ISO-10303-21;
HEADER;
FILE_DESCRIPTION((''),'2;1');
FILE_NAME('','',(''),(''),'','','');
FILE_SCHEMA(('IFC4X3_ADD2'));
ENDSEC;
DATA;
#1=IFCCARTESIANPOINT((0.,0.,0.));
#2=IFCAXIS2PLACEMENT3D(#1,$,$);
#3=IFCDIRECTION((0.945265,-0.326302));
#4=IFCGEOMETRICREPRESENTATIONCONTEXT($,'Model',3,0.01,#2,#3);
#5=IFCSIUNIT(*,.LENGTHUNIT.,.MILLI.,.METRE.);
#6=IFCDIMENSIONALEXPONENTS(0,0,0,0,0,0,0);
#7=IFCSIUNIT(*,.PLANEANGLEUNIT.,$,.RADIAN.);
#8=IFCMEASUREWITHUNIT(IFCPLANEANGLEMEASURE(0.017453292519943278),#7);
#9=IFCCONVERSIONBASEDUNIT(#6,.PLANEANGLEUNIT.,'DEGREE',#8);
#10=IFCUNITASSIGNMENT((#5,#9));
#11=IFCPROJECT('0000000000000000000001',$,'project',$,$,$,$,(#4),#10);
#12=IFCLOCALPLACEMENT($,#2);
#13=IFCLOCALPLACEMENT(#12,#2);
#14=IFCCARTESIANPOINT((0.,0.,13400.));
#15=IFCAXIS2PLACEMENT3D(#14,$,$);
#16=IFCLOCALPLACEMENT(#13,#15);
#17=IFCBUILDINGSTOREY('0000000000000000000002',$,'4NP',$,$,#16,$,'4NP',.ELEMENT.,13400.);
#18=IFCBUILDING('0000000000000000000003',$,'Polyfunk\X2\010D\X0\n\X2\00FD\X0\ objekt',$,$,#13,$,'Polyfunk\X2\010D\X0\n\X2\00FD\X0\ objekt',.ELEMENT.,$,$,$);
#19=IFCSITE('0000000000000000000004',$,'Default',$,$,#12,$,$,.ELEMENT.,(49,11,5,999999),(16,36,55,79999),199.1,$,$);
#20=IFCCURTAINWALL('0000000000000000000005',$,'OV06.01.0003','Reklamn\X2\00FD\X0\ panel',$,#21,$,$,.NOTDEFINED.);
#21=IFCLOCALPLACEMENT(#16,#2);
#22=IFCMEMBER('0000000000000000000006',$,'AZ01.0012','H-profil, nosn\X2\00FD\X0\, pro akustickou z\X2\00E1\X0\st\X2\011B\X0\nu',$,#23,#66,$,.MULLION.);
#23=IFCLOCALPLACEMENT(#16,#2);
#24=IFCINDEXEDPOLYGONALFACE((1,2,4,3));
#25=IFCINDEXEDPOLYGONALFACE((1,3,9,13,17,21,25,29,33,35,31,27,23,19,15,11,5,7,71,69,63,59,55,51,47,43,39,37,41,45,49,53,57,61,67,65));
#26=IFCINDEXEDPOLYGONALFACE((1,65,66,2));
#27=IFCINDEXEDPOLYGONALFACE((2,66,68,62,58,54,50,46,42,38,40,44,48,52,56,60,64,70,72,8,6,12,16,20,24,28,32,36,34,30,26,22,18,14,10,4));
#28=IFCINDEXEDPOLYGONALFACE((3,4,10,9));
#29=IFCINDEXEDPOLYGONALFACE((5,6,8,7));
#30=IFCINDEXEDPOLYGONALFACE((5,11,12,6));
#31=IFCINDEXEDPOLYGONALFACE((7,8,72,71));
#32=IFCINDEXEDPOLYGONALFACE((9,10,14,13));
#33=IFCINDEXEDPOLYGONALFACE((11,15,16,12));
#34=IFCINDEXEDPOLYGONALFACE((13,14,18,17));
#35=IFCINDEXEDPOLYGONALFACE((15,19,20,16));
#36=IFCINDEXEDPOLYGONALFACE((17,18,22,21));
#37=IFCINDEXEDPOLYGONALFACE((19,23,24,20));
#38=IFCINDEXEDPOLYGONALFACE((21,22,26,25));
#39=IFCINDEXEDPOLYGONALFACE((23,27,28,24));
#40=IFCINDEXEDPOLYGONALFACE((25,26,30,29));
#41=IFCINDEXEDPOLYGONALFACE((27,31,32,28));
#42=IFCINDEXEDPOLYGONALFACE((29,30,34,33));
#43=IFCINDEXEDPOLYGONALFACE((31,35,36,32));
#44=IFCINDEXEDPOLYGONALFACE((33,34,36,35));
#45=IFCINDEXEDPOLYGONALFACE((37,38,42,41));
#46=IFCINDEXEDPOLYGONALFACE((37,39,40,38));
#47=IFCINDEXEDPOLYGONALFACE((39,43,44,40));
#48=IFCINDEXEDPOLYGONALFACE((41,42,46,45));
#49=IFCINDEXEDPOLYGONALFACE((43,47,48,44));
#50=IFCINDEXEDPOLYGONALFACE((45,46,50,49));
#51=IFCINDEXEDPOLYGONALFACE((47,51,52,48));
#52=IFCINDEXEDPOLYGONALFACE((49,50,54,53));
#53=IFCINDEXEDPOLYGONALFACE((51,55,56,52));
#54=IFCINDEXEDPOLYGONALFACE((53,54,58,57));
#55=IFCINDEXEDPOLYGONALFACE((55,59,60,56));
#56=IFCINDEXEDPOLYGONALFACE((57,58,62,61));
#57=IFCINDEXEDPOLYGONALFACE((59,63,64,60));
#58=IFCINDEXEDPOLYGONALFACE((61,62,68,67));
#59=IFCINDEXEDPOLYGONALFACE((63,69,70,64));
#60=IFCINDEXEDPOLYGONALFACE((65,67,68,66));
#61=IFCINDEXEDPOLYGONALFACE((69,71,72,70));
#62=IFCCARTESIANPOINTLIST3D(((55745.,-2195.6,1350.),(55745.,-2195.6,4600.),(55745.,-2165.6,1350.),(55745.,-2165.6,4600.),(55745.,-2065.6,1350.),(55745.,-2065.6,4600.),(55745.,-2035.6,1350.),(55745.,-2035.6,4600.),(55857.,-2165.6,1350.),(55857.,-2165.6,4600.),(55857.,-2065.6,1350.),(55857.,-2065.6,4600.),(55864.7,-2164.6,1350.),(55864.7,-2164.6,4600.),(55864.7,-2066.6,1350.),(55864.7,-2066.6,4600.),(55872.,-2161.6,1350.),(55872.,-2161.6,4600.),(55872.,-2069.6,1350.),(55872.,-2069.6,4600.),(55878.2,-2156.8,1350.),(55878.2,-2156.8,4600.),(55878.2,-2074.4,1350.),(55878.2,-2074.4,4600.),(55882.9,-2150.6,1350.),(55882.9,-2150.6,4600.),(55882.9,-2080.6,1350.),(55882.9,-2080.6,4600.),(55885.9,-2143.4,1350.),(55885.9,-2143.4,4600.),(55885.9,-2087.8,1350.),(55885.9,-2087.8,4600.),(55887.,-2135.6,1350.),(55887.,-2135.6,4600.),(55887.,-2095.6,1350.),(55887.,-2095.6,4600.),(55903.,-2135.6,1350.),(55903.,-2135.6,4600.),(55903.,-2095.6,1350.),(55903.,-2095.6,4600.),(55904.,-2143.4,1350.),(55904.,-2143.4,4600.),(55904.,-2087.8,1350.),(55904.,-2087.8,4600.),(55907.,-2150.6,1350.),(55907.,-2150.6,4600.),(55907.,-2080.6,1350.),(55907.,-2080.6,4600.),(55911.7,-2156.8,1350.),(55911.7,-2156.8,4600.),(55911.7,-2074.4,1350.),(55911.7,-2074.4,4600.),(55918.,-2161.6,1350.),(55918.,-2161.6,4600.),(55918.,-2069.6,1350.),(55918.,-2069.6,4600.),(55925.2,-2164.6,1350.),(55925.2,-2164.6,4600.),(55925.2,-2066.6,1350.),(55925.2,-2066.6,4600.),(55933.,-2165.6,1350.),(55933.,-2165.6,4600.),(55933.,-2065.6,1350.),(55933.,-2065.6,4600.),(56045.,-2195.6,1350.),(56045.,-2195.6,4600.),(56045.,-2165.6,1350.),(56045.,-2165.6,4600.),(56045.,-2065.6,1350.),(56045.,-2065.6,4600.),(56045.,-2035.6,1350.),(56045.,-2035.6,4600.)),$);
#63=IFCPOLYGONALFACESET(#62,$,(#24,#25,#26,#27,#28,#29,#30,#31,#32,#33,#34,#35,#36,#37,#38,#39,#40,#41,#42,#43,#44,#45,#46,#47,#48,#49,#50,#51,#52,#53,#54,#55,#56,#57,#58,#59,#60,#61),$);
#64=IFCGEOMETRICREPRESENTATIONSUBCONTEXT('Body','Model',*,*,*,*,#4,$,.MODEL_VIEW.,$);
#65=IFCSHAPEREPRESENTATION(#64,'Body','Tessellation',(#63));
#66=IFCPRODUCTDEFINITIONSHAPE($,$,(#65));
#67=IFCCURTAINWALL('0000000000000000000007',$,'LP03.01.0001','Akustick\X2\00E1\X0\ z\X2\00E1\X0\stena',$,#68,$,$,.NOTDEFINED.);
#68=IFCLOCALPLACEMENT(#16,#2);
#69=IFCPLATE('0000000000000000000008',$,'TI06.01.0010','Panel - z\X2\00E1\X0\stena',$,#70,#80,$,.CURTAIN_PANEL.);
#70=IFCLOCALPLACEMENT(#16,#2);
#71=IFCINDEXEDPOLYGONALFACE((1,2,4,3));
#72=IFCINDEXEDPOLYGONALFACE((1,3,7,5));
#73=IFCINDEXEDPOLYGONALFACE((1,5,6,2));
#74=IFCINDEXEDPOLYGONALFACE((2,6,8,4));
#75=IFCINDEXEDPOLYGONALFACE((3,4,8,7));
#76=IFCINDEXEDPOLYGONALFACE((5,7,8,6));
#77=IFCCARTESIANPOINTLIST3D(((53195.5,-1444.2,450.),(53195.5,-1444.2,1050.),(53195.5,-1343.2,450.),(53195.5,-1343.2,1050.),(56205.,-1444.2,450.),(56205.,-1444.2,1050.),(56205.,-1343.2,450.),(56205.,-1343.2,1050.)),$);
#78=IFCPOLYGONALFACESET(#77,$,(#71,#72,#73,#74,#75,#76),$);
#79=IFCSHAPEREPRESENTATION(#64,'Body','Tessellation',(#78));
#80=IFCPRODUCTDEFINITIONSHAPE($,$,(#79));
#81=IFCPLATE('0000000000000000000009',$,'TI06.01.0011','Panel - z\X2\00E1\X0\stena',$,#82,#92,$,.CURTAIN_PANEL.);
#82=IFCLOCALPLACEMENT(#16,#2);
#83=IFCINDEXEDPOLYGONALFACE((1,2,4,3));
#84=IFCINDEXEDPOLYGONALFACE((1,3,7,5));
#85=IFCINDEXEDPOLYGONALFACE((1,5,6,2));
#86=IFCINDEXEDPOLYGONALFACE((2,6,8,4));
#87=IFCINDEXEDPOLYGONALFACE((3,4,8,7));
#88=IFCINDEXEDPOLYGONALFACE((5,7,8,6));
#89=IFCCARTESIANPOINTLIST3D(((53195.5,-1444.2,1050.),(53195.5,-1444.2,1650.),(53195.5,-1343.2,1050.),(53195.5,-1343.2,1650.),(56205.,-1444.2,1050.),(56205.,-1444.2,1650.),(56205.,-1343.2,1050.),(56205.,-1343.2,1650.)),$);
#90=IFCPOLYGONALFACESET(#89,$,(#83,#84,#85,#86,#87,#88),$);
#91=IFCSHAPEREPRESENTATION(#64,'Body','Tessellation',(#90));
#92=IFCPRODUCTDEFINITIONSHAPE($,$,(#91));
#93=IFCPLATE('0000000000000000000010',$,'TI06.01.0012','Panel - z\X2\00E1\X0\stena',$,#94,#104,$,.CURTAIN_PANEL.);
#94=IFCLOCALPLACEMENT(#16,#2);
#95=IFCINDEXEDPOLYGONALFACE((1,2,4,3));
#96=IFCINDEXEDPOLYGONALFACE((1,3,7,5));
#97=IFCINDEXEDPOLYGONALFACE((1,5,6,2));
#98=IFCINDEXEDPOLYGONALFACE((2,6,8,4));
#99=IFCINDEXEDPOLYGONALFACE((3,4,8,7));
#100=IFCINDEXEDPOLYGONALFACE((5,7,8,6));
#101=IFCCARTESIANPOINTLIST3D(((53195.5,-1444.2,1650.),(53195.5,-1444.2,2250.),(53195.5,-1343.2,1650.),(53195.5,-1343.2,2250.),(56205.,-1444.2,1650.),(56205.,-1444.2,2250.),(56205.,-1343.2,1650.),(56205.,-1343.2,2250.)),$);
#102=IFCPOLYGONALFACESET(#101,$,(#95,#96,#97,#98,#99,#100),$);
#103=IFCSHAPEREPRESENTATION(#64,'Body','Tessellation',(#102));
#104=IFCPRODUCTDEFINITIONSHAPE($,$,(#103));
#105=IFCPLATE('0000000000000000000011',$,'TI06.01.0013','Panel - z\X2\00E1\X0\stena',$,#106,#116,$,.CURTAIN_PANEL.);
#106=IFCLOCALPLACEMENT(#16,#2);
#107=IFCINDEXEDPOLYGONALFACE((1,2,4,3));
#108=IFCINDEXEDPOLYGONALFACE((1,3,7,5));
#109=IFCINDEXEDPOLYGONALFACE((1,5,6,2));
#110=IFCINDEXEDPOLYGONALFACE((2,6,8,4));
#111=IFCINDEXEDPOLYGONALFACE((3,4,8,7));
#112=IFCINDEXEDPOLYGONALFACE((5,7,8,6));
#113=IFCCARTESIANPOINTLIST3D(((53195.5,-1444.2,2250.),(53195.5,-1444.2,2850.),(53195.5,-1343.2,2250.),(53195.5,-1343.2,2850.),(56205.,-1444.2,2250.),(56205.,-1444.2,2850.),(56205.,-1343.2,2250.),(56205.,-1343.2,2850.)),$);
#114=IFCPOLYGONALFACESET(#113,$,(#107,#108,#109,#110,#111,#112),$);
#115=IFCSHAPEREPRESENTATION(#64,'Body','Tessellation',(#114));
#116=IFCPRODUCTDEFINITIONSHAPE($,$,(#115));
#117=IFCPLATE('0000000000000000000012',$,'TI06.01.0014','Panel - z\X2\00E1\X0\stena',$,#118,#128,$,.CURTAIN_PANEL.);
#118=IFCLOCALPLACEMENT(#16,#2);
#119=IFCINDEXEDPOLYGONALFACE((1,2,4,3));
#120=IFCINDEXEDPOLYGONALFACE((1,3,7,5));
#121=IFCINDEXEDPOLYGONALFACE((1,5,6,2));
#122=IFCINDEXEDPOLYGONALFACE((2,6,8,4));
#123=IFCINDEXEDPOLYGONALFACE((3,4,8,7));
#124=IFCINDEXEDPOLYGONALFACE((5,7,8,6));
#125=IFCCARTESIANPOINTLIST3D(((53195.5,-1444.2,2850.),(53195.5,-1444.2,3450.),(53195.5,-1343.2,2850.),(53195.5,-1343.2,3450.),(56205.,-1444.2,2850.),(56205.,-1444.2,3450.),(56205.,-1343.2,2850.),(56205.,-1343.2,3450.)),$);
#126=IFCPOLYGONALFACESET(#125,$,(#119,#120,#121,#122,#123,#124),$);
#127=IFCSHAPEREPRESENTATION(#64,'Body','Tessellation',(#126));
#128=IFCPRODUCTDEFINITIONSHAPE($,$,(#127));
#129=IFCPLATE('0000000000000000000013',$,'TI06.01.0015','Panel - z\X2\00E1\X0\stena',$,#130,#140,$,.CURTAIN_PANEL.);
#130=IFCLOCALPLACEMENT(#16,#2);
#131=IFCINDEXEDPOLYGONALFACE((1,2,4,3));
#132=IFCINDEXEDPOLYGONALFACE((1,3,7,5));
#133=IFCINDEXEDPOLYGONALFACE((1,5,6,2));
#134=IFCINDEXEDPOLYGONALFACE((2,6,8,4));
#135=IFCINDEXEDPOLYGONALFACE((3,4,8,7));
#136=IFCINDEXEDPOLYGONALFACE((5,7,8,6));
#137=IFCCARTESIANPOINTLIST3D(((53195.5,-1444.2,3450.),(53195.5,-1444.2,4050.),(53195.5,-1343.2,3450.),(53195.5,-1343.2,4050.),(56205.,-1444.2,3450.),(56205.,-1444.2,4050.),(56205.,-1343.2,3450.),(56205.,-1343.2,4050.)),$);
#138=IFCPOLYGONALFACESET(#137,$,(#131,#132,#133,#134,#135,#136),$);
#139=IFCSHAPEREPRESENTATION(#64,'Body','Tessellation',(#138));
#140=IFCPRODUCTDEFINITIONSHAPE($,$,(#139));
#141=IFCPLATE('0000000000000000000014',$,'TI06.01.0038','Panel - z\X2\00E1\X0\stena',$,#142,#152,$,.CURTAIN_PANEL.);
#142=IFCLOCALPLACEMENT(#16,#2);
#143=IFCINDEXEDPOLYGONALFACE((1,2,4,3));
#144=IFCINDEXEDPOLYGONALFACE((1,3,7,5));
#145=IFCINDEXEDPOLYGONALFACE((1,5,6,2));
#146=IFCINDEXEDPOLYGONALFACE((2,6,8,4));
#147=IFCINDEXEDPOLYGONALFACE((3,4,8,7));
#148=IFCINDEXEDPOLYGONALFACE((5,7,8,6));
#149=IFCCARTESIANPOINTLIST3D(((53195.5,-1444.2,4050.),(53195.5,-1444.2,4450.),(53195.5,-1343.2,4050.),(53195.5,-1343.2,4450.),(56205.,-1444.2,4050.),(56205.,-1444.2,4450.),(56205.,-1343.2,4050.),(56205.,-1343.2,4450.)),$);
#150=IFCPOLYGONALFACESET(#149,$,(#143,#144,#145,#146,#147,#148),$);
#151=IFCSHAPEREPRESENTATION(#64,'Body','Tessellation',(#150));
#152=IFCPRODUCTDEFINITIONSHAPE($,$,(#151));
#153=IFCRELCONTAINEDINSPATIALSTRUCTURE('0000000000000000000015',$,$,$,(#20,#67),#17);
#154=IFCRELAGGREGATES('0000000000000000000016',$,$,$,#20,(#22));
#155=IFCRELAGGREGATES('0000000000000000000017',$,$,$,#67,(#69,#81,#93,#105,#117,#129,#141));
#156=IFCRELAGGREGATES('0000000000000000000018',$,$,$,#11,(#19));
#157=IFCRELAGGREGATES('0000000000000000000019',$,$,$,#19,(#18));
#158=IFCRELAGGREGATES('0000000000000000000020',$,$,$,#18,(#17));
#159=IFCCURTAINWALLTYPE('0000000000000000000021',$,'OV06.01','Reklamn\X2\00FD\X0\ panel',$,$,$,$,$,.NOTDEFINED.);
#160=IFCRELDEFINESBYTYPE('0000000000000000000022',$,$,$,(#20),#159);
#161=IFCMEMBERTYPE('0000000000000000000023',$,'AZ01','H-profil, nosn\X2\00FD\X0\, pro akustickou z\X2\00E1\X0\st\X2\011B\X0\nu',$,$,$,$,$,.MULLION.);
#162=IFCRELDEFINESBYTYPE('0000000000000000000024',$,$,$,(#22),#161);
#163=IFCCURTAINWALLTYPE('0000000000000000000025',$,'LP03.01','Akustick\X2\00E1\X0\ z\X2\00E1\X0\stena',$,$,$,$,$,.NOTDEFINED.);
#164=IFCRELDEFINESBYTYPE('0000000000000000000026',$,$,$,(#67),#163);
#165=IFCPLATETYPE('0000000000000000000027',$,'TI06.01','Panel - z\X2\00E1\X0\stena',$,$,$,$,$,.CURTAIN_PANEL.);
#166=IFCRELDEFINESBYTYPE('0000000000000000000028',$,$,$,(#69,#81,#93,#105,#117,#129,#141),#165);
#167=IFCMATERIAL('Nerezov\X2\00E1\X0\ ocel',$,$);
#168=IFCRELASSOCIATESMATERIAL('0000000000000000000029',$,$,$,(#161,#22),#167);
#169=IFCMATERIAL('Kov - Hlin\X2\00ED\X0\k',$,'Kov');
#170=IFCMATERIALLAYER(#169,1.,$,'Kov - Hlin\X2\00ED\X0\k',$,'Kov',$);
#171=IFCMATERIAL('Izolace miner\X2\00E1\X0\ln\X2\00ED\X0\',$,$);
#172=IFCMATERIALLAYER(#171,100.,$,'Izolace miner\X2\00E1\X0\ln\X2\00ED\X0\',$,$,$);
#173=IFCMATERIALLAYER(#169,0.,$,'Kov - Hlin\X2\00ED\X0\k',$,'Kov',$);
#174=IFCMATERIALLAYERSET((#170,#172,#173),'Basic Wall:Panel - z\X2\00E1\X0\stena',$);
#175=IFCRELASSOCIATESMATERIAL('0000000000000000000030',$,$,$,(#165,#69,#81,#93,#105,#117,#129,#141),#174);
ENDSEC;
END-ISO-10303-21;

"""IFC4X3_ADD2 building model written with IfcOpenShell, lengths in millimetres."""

from ifc_helpers import new_model, entity, si_unit, converted_unit, direction, frame, frame_2d, origin, place, context, subcontext, project, spatial, polyline, circle_curve, parameter, trimmed, segment, composite_curve, rectangle, outline, extrude, source, transform, mapped, material, layer, layer_set, layer_usage, material_profile, profile_set, profile_usage, type_object, element, aggregate, save


model = new_model("IFC4X3_ADD2")

# Units and contexts
model_context = context("Model", 3, precision=0.01, world=origin(), true_north=direction((0.945265, -0.326302)))
body_context = subcontext(model_context, "Body", "Model", "MODEL_VIEW")
ifc_project = project(units=[si_unit("LENGTHUNIT", "METRE", prefix="MILLI"), converted_unit("PLANEANGLEUNIT", "DEGREE", entity("IfcPlaneAngleMeasure", 0.017453292519943278), si_unit("PLANEANGLEUNIT", "RADIAN"), dimensions=[0, 0, 0, 0, 0, 0, 0])], contexts=[model_context])

# Site, building, storey
site_placement = place(None, origin())
site = spatial("IfcSite", under=ifc_project, at=site_placement, Name="Default", CompositionType="ELEMENT", RefLatitude=(49, 11, 5, 999999), RefLongitude=(16, 36, 55, 79999), RefElevation=199.1)
building_placement = place(site_placement, origin())
building = spatial("IfcBuilding", under=site, at=building_placement, Name="Polyfunkčný objekt", LongName="Polyfunkčný objekt", CompositionType="ELEMENT")
storey_placement = place(building_placement, frame((0.0, 0.0, 13400.0)))
storey = spatial("IfcBuildingStorey", under=building, at=storey_placement, Name="4NP", LongName="4NP", CompositionType="ELEMENT", Elevation=13400.0)

# Shared definitions
curtain_wall_type_1 = type_object("IfcCurtainWallType", Name="LP03.01", Description="Akustická zástena", PredefinedType="NOTDEFINED")
ifc_material_1 = material(Name="Nerezová ocel")
ifc_material_profile = material_profile(ifc_material_1, outline(composite_curve([segment(polyline([(50.0, -150.0), (80.0, -150.0)]), True, "CONTINUOUS"), segment(polyline([(80.0, -150.0), (80.0, 150.0)]), True, "CONTINUOUS"), segment(polyline([(80.0, 150.0), (50.0, 150.0)]), True, "CONTINUOUS"), segment(polyline([(50.0, 150.0), (50.0, 38.0)]), True, "CONTINUOUS"), segment(trimmed(circle_curve(frame_2d((20.0, 38.0), x_axis=(0.0, 1.0)), 30.0), [parameter(180.0)], [parameter(270.0)], True, "PARAMETER"), False, "CONTINUOUS"), segment(polyline([(20.0, 8.0), (-20.0, 8.0)]), True, "CONTINUOUS"), segment(trimmed(circle_curve(frame_2d((-20.0, 38.0), x_axis=(0.0, 1.0)), 30.0), [parameter(90.0)], [parameter(180.0)], True, "PARAMETER"), False, "CONTINUOUS"), segment(polyline([(-50.0, 38.0), (-50.0, 150.0)]), True, "CONTINUOUS"), segment(polyline([(-50.0, 150.0), (-80.0, 150.0)]), True, "CONTINUOUS"), segment(polyline([(-80.0, 150.0), (-80.0, -150.0)]), True, "CONTINUOUS"), segment(polyline([(-80.0, -150.0), (-50.0, -150.0)]), True, "CONTINUOUS"), segment(polyline([(-50.0, -150.0), (-50.0, -38.0)]), True, "CONTINUOUS"), segment(trimmed(circle_curve(frame_2d((-20.0, -38.0), x_axis=(0.0, 1.0)), 30.0), [parameter(0.0)], [parameter(90.0)], True, "PARAMETER"), False, "CONTINUOUS"), segment(polyline([(-20.0, -8.0), (20.0, -8.0)]), True, "CONTINUOUS"), segment(trimmed(circle_curve(frame_2d((20.0, -38.0), x_axis=(0.0, 1.0)), 30.0), [parameter(270.0)], [parameter(0.0)], True, "PARAMETER"), False, "CONTINUOUS"), segment(polyline([(50.0, -38.0), (50.0, -150.0)]), True, "CONTINUOUS")], self_intersect=False)), Name="Profil zástena")
ifc_profile_set = profile_set([ifc_material_profile], Name="Profil zástena")
ifc_profile_usage = profile_usage(ifc_profile_set)
member_type = type_object("IfcMemberType", Name="AZ01", Description="H-profil, nosný, pro akustickou zástěnu", PredefinedType="MULLION", material=ifc_profile_set)

# Curtain wall, member
curtain_wall_type_2 = type_object("IfcCurtainWallType", Name="OV06.01", Description="Reklamný panel", PredefinedType="NOTDEFINED")
curtain_wall_1_placement = place(storey_placement, frame((0.0, 0.0, -13400.0)))
curtain_wall_1 = element("IfcCurtainWall", 1, at=curtain_wall_1_placement, inside=storey, type_object=curtain_wall_type_2, Name="OV06.01.0003", Description="Reklamný panel", PredefinedType="NOTDEFINED")
shared_shape_1 = source(origin(), body_context, "Body", "SweptSolid", [
    extrude(outline(composite_curve([segment(polyline([(-150.0, -50.0), (-150.0, -80.0)]), True, "CONTINUOUS"), segment(polyline([(-150.0, -80.0), (150.0, -80.0)]), True, "CONTINUOUS"), segment(polyline([(150.0, -80.0), (150.0, -50.0)]), True, "CONTINUOUS"), segment(polyline([(150.0, -50.0), (38.0, -50.0)]), True, "CONTINUOUS"), segment(trimmed(circle_curve(frame_2d((38.0, -20.0), x_axis=(1.0, 0.0)), 30.0), [parameter(180.0)], [parameter(270.0)], True, "PARAMETER"), False, "CONTINUOUS"), segment(polyline([(8.0, -20.0), (8.0, 20.0)]), True, "CONTINUOUS"), segment(trimmed(circle_curve(frame_2d((38.0, 20.0), x_axis=(1.0, 0.0)), 30.0), [parameter(90.0)], [parameter(180.0)], True, "PARAMETER"), False, "CONTINUOUS"), segment(polyline([(38.0, 50.0), (150.0, 50.0)]), True, "CONTINUOUS"), segment(polyline([(150.0, 50.0), (150.0, 80.0)]), True, "CONTINUOUS"), segment(polyline([(150.0, 80.0), (-150.0, 80.0)]), True, "CONTINUOUS"), segment(polyline([(-150.0, 80.0), (-150.0, 50.0)]), True, "CONTINUOUS"), segment(polyline([(-150.0, 50.0), (-38.0, 50.0)]), True, "CONTINUOUS"), segment(trimmed(circle_curve(frame_2d((-38.0, 20.0), x_axis=(1.0, 0.0)), 30.0), [parameter(0.0)], [parameter(90.0)], True, "PARAMETER"), False, "CONTINUOUS"), segment(polyline([(-8.0, 20.0), (-8.0, -20.0)]), True, "CONTINUOUS"), segment(trimmed(circle_curve(frame_2d((-38.0, -20.0), x_axis=(1.0, 0.0)), 30.0), [parameter(270.0)], [parameter(0.0)], True, "PARAMETER"), False, "CONTINUOUS"), segment(polyline([(-38.0, -50.0), (-150.0, -50.0)]), True, "CONTINUOUS")], self_intersect=False)), frame((-150.0, 0.0, -3250.0), z_axis=(0.0, 0.0, -1.0), x_axis=(1.0, 0.0, 0.0)), (0.0, 0.0, -1.0), 3250.0),
])
member_1_placement = place(curtain_wall_1_placement, frame((56045.0, -2115.6, 14750.0), z_axis=(0.0, 0.0, -1.0), x_axis=(1.0, 0.0, 0.0)))
member_1 = element("IfcMember", 2, at=member_1_placement, type_object=member_type, material=ifc_profile_usage, Name="AZ01.0012", Description="H-profil, nosný, pro akustickou zástěnu", PredefinedType="MULLION", context=body_context, shape_type="MappedRepresentation", body=[
    mapped(shared_shape_1, transform((0.0, 0.0, 0.0), scale=1.0)),
])
aggregate(curtain_wall_1, [member_1])

# Curtain wall, plates
curtain_wall_2_placement = place(storey_placement, frame((0.0, 0.0, -13400.0)))
curtain_wall_2 = element("IfcCurtainWall", 3, at=curtain_wall_2_placement, inside=storey, type_object=curtain_wall_type_1, Name="LP03.01.0001", Description="Akustická zástena", PredefinedType="NOTDEFINED")
ifc_material_2 = material(Name="Kov - Hliník", Category="Kov")
ifc_layer_1 = layer(ifc_material_2, 1.0, Name="Kov - Hliník", Category="Kov")
ifc_material_3 = material(Name="Izolace minerální")
ifc_layer_2 = layer(ifc_material_3, 100.0, Name="Izolace minerální")
ifc_layer_3 = layer(ifc_material_2, 0.0, Name="Kov - Hliník", Category="Kov")
ifc_layer_set_1 = layer_set([ifc_layer_1, ifc_layer_2, ifc_layer_3], Name="Basic Wall:Panel - zástena")
ifc_layer_usage_1 = layer_usage(ifc_layer_set_1, "AXIS2", "POSITIVE", -50.5)
plate_type = type_object("IfcPlateType", Name="TI06.01", Description="Panel - zástena", PredefinedType="CURTAIN_PANEL", material=ifc_layer_set_1)
plate_1_placement = place(storey_placement, frame((53195.5, -1393.7, 450.0)))
plate_1 = element("IfcPlate", 4, at=plate_1_placement, type_object=plate_type, material=ifc_layer_usage_1, Name="TI06.01.0010", Description="Panel - zástena", PredefinedType="CURTAIN_PANEL", context=body_context, shape_type="SweptSolid", body=[
    extrude(rectangle(XDim=101.0, YDim=3009.5, at=frame_2d((0.0, 0.0), x_axis=(1.0, 0.0))), frame((1504.7, 0.0, 0.0), z_axis=(0.0, 0.0, 1.0), x_axis=(0.0, 1.0, 0.0)), (0.0, 0.0, 1.0), 600.0),
])
ifc_layer_usage_2 = layer_usage(ifc_layer_set_1, "AXIS2", "POSITIVE", -50.5)
plate_2_placement = place(storey_placement, frame((53195.5, -1393.7, 1050.0)))
plate_2 = element("IfcPlate", 5, at=plate_2_placement, type_object=plate_type, material=ifc_layer_usage_2, Name="TI06.01.0011", Description="Panel - zástena", PredefinedType="CURTAIN_PANEL", context=body_context, shape_type="SweptSolid", body=[
    extrude(rectangle(XDim=101.0, YDim=3009.5, at=frame_2d((0.0, 0.0), x_axis=(1.0, 0.0))), frame((1504.7, 0.0, 0.0), z_axis=(0.0, 0.0, 1.0), x_axis=(0.0, 1.0, 0.0)), (0.0, 0.0, 1.0), 600.0),
])
ifc_layer_usage_3 = layer_usage(ifc_layer_set_1, "AXIS2", "POSITIVE", -50.5)
plate_3_placement = place(storey_placement, frame((53195.5, -1393.7, 1650.0)))
plate_3 = element("IfcPlate", 6, at=plate_3_placement, type_object=plate_type, material=ifc_layer_usage_3, Name="TI06.01.0012", Description="Panel - zástena", PredefinedType="CURTAIN_PANEL", context=body_context, shape_type="SweptSolid", body=[
    extrude(rectangle(XDim=101.0, YDim=3009.5, at=frame_2d((0.0, 0.0), x_axis=(1.0, 0.0))), frame((1504.7, 0.0, 0.0), z_axis=(0.0, 0.0, 1.0), x_axis=(0.0, 1.0, 0.0)), (0.0, 0.0, 1.0), 600.0),
])
ifc_layer_usage_4 = layer_usage(ifc_layer_set_1, "AXIS2", "POSITIVE", -50.5)
plate_4_placement = place(storey_placement, frame((53195.5, -1393.7, 2250.0)))
plate_4 = element("IfcPlate", 7, at=plate_4_placement, type_object=plate_type, material=ifc_layer_usage_4, Name="TI06.01.0013", Description="Panel - zástena", PredefinedType="CURTAIN_PANEL", context=body_context, shape_type="SweptSolid", body=[
    extrude(rectangle(XDim=101.0, YDim=3009.5, at=frame_2d((0.0, 0.0), x_axis=(1.0, 0.0))), frame((1504.7, 0.0, 0.0), z_axis=(0.0, 0.0, 1.0), x_axis=(0.0, 1.0, 0.0)), (0.0, 0.0, 1.0), 600.0),
])
ifc_layer_usage_5 = layer_usage(ifc_layer_set_1, "AXIS2", "POSITIVE", -50.5)
plate_5_placement = place(storey_placement, frame((53195.5, -1393.7, 2850.0)))
plate_5 = element("IfcPlate", 8, at=plate_5_placement, type_object=plate_type, material=ifc_layer_usage_5, Name="TI06.01.0014", Description="Panel - zástena", PredefinedType="CURTAIN_PANEL", context=body_context, shape_type="SweptSolid", body=[
    extrude(rectangle(XDim=101.0, YDim=3009.5, at=frame_2d((0.0, 0.0), x_axis=(1.0, 0.0))), frame((1504.7, 0.0, 0.0), z_axis=(0.0, 0.0, 1.0), x_axis=(0.0, 1.0, 0.0)), (0.0, 0.0, 1.0), 600.0),
])
ifc_layer_usage_6 = layer_usage(ifc_layer_set_1, "AXIS2", "POSITIVE", -50.5)
plate_6_placement = place(storey_placement, frame((53195.5, -1393.7, 3450.0)))
plate_6 = element("IfcPlate", 9, at=plate_6_placement, type_object=plate_type, material=ifc_layer_usage_6, Name="TI06.01.0015", Description="Panel - zástena", PredefinedType="CURTAIN_PANEL", context=body_context, shape_type="SweptSolid", body=[
    extrude(rectangle(XDim=101.0, YDim=3009.5, at=frame_2d((0.0, 0.0), x_axis=(1.0, 0.0))), frame((1504.7, 0.0, 0.0), z_axis=(0.0, 0.0, 1.0), x_axis=(0.0, 1.0, 0.0)), (0.0, 0.0, 1.0), 600.0),
])
ifc_layer_usage_7 = layer_usage(ifc_layer_set_1, "AXIS2", "POSITIVE", -50.5)
plate_7_placement = place(storey_placement, frame((53195.5, -1393.7, 4050.0)))
plate_7 = element("IfcPlate", 10, at=plate_7_placement, type_object=plate_type, material=ifc_layer_usage_7, Name="TI06.01.0038", Description="Panel - zástena", PredefinedType="CURTAIN_PANEL", context=body_context, shape_type="SweptSolid", body=[
    extrude(rectangle(XDim=101.0, YDim=3009.5, at=frame_2d((0.0, 0.0), x_axis=(1.0, 0.0))), frame((1504.7, 0.0, 0.0), z_axis=(0.0, 0.0, 1.0), x_axis=(0.0, 1.0, 0.0)), (0.0, 0.0, 1.0), 400.0),
])
aggregate(curtain_wall_2, [plate_1, plate_2, plate_3, plate_4, plate_5, plate_6, plate_7])

save(model, "model.ifc")
